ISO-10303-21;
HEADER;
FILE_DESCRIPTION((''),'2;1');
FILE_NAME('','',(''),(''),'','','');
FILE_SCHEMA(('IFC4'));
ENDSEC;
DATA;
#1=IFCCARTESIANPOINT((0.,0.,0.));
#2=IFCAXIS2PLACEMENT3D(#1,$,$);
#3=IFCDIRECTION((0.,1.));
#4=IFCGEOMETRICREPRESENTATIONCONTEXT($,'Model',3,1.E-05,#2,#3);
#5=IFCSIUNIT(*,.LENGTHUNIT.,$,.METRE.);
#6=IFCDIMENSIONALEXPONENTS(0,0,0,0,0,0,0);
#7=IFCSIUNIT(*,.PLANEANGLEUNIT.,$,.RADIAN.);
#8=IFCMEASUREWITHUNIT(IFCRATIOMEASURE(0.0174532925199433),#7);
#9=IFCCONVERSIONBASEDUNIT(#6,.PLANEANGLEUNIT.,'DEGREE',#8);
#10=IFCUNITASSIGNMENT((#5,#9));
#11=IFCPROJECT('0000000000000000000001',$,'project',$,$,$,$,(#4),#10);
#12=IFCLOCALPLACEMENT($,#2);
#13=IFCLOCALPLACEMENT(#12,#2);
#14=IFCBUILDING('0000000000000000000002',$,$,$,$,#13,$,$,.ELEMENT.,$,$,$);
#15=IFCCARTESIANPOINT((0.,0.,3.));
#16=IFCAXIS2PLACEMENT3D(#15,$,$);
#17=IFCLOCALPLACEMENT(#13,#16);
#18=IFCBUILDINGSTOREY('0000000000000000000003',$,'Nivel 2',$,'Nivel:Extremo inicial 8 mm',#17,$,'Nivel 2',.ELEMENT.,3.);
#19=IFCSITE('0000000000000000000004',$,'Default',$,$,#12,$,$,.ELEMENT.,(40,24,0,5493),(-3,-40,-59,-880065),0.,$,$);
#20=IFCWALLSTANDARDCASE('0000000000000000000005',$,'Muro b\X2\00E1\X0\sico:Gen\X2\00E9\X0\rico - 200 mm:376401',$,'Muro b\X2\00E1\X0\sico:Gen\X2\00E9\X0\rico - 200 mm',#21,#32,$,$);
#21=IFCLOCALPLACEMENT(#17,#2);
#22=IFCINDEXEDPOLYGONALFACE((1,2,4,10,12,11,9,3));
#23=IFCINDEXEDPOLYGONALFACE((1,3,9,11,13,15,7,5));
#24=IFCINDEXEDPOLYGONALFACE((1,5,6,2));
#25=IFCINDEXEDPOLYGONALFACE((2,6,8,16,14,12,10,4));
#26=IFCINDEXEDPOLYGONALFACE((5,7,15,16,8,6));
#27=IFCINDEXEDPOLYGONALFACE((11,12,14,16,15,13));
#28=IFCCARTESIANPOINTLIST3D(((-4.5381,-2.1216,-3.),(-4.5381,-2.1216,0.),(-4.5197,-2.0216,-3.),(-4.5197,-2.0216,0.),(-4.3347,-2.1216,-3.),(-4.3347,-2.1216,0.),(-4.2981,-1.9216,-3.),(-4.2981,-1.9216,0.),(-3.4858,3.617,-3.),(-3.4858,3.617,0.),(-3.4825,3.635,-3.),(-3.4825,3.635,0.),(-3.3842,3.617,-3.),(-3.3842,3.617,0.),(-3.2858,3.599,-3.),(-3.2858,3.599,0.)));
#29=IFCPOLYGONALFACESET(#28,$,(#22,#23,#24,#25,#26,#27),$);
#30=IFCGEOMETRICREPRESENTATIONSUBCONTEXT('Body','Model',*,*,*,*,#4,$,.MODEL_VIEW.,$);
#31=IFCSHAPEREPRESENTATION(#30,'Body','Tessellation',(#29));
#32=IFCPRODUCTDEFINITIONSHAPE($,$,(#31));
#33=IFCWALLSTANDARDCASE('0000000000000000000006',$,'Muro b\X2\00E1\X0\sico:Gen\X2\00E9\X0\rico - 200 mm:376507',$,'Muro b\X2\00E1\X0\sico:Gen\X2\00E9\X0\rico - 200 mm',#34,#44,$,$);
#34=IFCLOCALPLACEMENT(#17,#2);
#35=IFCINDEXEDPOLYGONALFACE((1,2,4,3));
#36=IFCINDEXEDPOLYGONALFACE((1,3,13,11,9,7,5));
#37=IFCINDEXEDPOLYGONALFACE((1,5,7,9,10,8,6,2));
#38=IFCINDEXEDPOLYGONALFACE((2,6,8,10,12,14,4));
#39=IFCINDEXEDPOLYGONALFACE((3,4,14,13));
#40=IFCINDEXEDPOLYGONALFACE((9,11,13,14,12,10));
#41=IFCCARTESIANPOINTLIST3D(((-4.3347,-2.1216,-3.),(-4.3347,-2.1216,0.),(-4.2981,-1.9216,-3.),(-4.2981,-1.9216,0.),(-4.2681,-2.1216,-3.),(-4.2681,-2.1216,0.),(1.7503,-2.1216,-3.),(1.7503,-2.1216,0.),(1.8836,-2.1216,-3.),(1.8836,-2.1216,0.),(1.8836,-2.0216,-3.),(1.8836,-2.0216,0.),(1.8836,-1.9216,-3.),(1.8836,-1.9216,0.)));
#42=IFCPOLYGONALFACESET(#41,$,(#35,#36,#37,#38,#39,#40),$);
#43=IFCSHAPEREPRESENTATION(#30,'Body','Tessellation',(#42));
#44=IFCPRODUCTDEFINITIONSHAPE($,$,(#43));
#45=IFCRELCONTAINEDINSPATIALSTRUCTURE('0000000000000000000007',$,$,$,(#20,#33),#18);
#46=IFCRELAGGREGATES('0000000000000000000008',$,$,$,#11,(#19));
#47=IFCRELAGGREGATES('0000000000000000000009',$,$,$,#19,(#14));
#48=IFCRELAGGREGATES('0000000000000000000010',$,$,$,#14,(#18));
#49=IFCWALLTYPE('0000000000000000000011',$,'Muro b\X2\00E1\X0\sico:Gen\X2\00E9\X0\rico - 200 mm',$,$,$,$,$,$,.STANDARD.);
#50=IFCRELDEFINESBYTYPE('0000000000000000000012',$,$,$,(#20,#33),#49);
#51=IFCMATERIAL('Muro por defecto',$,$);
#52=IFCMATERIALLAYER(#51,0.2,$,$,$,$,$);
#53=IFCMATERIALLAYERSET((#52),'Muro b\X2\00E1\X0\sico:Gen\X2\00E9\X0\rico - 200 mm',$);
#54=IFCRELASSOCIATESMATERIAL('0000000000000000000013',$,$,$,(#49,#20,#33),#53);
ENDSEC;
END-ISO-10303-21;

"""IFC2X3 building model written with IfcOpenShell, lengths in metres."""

from ifc_helpers import new_model, entity, si_unit, converted_unit, direction, frame, origin, place, context, subcontext, project, spatial, polyline, outline, extrude, material, layer, layer_set, layer_usage, type_object, element, save


model = new_model("IFC2X3")

# Units and contexts
model_context = context("Model", 3, precision=1e-05, world=origin(), true_north=direction((0.0, 1.0)))
body_context = subcontext(model_context, "Body", "Model", "MODEL_VIEW")
ifc_project = project(units=[si_unit("LENGTHUNIT", "METRE"), converted_unit("PLANEANGLEUNIT", "DEGREE", entity("IfcRatioMeasure", 0.0174532925199433), si_unit("PLANEANGLEUNIT", "RADIAN"), dimensions=[0, 0, 0, 0, 0, 0, 0])], contexts=[model_context])

# Site, building, storey
site_placement = place(None, origin())
site = spatial("IfcSite", under=ifc_project, at=site_placement, Name="Default", CompositionType="ELEMENT", RefLatitude=(40, 24, 0, 5493), RefLongitude=(-3, -40, -59, -880065), RefElevation=0.0)
building_placement = place(site_placement, origin())
building = spatial("IfcBuilding", under=site, at=building_placement, CompositionType="ELEMENT")
storey_placement = place(building_placement, frame((0.0, 0.0, 3.0)))
storey = spatial("IfcBuildingStorey", under=building, at=storey_placement, Name="Nivel 2", ObjectType="Nivel:Extremo inicial 8 mm", LongName="Nivel 2", CompositionType="ELEMENT", Elevation=3.0)

# Walls
ifc_material_1 = material(Name="Muro por defecto")
ifc_layer_1 = layer(ifc_material_1, 0.2)
ifc_layer_set_1 = layer_set([ifc_layer_1], Name="Muro básico:Genérico - 200 mm")
ifc_layer_usage_1 = layer_usage(ifc_layer_set_1, "AXIS2", "NEGATIVE", 0.1)
wall_type = type_object("IfcWallType", Name="Muro básico:Genérico - 200 mm", PredefinedType="STANDARD", material=ifc_layer_set_1)
wall_1_placement = place(storey_placement, frame((-3.3842, 3.617, -3.0), z_axis=(0.0, 0.0, 1.0), x_axis=(-0.180357, -0.983601, 0.0)))
element("IfcWallStandardCase", 1, at=wall_1_placement, inside=storey, type_object=wall_type, material=ifc_layer_usage_1, Name="Muro básico:Genérico - 200 mm:376401", ObjectType="Muro básico:Genérico - 200 mm", context=body_context, shape_type="SweptSolid", body=[
    extrude(outline(polyline([(5.8526, -0.1), (5.8159, 0.1), (5.6126, 0.1), (0.0, 0.1), (0.0, 0.0), (0.0, -0.1), (0.0183, -0.1), (5.7509, -0.1), (5.8526, -0.1)])), origin(), (0.0, 0.0, 1.0), 3.0),
])
wall_2_placement = place(storey_placement, frame((-4.3347, -2.0216, -3.0)))
element("IfcWallStandardCase", 2, at=wall_2_placement, inside=storey, type_object=wall_type, material=ifc_layer_usage_1, Name="Muro básico:Genérico - 200 mm:376507", ObjectType="Muro básico:Genérico - 200 mm", context=body_context, shape_type="SweptSolid", body=[
    extrude(outline(polyline([(6.2183, -0.1), (6.2183, 0.0), (6.2183, 0.1), (0.0367, 0.1), (0.0, -0.1), (0.0667, -0.1), (6.085, -0.1), (6.2183, -0.1)])), origin(), (0.0, 0.0, 1.0), 3.0),
])

save(model, "model.ifc")
